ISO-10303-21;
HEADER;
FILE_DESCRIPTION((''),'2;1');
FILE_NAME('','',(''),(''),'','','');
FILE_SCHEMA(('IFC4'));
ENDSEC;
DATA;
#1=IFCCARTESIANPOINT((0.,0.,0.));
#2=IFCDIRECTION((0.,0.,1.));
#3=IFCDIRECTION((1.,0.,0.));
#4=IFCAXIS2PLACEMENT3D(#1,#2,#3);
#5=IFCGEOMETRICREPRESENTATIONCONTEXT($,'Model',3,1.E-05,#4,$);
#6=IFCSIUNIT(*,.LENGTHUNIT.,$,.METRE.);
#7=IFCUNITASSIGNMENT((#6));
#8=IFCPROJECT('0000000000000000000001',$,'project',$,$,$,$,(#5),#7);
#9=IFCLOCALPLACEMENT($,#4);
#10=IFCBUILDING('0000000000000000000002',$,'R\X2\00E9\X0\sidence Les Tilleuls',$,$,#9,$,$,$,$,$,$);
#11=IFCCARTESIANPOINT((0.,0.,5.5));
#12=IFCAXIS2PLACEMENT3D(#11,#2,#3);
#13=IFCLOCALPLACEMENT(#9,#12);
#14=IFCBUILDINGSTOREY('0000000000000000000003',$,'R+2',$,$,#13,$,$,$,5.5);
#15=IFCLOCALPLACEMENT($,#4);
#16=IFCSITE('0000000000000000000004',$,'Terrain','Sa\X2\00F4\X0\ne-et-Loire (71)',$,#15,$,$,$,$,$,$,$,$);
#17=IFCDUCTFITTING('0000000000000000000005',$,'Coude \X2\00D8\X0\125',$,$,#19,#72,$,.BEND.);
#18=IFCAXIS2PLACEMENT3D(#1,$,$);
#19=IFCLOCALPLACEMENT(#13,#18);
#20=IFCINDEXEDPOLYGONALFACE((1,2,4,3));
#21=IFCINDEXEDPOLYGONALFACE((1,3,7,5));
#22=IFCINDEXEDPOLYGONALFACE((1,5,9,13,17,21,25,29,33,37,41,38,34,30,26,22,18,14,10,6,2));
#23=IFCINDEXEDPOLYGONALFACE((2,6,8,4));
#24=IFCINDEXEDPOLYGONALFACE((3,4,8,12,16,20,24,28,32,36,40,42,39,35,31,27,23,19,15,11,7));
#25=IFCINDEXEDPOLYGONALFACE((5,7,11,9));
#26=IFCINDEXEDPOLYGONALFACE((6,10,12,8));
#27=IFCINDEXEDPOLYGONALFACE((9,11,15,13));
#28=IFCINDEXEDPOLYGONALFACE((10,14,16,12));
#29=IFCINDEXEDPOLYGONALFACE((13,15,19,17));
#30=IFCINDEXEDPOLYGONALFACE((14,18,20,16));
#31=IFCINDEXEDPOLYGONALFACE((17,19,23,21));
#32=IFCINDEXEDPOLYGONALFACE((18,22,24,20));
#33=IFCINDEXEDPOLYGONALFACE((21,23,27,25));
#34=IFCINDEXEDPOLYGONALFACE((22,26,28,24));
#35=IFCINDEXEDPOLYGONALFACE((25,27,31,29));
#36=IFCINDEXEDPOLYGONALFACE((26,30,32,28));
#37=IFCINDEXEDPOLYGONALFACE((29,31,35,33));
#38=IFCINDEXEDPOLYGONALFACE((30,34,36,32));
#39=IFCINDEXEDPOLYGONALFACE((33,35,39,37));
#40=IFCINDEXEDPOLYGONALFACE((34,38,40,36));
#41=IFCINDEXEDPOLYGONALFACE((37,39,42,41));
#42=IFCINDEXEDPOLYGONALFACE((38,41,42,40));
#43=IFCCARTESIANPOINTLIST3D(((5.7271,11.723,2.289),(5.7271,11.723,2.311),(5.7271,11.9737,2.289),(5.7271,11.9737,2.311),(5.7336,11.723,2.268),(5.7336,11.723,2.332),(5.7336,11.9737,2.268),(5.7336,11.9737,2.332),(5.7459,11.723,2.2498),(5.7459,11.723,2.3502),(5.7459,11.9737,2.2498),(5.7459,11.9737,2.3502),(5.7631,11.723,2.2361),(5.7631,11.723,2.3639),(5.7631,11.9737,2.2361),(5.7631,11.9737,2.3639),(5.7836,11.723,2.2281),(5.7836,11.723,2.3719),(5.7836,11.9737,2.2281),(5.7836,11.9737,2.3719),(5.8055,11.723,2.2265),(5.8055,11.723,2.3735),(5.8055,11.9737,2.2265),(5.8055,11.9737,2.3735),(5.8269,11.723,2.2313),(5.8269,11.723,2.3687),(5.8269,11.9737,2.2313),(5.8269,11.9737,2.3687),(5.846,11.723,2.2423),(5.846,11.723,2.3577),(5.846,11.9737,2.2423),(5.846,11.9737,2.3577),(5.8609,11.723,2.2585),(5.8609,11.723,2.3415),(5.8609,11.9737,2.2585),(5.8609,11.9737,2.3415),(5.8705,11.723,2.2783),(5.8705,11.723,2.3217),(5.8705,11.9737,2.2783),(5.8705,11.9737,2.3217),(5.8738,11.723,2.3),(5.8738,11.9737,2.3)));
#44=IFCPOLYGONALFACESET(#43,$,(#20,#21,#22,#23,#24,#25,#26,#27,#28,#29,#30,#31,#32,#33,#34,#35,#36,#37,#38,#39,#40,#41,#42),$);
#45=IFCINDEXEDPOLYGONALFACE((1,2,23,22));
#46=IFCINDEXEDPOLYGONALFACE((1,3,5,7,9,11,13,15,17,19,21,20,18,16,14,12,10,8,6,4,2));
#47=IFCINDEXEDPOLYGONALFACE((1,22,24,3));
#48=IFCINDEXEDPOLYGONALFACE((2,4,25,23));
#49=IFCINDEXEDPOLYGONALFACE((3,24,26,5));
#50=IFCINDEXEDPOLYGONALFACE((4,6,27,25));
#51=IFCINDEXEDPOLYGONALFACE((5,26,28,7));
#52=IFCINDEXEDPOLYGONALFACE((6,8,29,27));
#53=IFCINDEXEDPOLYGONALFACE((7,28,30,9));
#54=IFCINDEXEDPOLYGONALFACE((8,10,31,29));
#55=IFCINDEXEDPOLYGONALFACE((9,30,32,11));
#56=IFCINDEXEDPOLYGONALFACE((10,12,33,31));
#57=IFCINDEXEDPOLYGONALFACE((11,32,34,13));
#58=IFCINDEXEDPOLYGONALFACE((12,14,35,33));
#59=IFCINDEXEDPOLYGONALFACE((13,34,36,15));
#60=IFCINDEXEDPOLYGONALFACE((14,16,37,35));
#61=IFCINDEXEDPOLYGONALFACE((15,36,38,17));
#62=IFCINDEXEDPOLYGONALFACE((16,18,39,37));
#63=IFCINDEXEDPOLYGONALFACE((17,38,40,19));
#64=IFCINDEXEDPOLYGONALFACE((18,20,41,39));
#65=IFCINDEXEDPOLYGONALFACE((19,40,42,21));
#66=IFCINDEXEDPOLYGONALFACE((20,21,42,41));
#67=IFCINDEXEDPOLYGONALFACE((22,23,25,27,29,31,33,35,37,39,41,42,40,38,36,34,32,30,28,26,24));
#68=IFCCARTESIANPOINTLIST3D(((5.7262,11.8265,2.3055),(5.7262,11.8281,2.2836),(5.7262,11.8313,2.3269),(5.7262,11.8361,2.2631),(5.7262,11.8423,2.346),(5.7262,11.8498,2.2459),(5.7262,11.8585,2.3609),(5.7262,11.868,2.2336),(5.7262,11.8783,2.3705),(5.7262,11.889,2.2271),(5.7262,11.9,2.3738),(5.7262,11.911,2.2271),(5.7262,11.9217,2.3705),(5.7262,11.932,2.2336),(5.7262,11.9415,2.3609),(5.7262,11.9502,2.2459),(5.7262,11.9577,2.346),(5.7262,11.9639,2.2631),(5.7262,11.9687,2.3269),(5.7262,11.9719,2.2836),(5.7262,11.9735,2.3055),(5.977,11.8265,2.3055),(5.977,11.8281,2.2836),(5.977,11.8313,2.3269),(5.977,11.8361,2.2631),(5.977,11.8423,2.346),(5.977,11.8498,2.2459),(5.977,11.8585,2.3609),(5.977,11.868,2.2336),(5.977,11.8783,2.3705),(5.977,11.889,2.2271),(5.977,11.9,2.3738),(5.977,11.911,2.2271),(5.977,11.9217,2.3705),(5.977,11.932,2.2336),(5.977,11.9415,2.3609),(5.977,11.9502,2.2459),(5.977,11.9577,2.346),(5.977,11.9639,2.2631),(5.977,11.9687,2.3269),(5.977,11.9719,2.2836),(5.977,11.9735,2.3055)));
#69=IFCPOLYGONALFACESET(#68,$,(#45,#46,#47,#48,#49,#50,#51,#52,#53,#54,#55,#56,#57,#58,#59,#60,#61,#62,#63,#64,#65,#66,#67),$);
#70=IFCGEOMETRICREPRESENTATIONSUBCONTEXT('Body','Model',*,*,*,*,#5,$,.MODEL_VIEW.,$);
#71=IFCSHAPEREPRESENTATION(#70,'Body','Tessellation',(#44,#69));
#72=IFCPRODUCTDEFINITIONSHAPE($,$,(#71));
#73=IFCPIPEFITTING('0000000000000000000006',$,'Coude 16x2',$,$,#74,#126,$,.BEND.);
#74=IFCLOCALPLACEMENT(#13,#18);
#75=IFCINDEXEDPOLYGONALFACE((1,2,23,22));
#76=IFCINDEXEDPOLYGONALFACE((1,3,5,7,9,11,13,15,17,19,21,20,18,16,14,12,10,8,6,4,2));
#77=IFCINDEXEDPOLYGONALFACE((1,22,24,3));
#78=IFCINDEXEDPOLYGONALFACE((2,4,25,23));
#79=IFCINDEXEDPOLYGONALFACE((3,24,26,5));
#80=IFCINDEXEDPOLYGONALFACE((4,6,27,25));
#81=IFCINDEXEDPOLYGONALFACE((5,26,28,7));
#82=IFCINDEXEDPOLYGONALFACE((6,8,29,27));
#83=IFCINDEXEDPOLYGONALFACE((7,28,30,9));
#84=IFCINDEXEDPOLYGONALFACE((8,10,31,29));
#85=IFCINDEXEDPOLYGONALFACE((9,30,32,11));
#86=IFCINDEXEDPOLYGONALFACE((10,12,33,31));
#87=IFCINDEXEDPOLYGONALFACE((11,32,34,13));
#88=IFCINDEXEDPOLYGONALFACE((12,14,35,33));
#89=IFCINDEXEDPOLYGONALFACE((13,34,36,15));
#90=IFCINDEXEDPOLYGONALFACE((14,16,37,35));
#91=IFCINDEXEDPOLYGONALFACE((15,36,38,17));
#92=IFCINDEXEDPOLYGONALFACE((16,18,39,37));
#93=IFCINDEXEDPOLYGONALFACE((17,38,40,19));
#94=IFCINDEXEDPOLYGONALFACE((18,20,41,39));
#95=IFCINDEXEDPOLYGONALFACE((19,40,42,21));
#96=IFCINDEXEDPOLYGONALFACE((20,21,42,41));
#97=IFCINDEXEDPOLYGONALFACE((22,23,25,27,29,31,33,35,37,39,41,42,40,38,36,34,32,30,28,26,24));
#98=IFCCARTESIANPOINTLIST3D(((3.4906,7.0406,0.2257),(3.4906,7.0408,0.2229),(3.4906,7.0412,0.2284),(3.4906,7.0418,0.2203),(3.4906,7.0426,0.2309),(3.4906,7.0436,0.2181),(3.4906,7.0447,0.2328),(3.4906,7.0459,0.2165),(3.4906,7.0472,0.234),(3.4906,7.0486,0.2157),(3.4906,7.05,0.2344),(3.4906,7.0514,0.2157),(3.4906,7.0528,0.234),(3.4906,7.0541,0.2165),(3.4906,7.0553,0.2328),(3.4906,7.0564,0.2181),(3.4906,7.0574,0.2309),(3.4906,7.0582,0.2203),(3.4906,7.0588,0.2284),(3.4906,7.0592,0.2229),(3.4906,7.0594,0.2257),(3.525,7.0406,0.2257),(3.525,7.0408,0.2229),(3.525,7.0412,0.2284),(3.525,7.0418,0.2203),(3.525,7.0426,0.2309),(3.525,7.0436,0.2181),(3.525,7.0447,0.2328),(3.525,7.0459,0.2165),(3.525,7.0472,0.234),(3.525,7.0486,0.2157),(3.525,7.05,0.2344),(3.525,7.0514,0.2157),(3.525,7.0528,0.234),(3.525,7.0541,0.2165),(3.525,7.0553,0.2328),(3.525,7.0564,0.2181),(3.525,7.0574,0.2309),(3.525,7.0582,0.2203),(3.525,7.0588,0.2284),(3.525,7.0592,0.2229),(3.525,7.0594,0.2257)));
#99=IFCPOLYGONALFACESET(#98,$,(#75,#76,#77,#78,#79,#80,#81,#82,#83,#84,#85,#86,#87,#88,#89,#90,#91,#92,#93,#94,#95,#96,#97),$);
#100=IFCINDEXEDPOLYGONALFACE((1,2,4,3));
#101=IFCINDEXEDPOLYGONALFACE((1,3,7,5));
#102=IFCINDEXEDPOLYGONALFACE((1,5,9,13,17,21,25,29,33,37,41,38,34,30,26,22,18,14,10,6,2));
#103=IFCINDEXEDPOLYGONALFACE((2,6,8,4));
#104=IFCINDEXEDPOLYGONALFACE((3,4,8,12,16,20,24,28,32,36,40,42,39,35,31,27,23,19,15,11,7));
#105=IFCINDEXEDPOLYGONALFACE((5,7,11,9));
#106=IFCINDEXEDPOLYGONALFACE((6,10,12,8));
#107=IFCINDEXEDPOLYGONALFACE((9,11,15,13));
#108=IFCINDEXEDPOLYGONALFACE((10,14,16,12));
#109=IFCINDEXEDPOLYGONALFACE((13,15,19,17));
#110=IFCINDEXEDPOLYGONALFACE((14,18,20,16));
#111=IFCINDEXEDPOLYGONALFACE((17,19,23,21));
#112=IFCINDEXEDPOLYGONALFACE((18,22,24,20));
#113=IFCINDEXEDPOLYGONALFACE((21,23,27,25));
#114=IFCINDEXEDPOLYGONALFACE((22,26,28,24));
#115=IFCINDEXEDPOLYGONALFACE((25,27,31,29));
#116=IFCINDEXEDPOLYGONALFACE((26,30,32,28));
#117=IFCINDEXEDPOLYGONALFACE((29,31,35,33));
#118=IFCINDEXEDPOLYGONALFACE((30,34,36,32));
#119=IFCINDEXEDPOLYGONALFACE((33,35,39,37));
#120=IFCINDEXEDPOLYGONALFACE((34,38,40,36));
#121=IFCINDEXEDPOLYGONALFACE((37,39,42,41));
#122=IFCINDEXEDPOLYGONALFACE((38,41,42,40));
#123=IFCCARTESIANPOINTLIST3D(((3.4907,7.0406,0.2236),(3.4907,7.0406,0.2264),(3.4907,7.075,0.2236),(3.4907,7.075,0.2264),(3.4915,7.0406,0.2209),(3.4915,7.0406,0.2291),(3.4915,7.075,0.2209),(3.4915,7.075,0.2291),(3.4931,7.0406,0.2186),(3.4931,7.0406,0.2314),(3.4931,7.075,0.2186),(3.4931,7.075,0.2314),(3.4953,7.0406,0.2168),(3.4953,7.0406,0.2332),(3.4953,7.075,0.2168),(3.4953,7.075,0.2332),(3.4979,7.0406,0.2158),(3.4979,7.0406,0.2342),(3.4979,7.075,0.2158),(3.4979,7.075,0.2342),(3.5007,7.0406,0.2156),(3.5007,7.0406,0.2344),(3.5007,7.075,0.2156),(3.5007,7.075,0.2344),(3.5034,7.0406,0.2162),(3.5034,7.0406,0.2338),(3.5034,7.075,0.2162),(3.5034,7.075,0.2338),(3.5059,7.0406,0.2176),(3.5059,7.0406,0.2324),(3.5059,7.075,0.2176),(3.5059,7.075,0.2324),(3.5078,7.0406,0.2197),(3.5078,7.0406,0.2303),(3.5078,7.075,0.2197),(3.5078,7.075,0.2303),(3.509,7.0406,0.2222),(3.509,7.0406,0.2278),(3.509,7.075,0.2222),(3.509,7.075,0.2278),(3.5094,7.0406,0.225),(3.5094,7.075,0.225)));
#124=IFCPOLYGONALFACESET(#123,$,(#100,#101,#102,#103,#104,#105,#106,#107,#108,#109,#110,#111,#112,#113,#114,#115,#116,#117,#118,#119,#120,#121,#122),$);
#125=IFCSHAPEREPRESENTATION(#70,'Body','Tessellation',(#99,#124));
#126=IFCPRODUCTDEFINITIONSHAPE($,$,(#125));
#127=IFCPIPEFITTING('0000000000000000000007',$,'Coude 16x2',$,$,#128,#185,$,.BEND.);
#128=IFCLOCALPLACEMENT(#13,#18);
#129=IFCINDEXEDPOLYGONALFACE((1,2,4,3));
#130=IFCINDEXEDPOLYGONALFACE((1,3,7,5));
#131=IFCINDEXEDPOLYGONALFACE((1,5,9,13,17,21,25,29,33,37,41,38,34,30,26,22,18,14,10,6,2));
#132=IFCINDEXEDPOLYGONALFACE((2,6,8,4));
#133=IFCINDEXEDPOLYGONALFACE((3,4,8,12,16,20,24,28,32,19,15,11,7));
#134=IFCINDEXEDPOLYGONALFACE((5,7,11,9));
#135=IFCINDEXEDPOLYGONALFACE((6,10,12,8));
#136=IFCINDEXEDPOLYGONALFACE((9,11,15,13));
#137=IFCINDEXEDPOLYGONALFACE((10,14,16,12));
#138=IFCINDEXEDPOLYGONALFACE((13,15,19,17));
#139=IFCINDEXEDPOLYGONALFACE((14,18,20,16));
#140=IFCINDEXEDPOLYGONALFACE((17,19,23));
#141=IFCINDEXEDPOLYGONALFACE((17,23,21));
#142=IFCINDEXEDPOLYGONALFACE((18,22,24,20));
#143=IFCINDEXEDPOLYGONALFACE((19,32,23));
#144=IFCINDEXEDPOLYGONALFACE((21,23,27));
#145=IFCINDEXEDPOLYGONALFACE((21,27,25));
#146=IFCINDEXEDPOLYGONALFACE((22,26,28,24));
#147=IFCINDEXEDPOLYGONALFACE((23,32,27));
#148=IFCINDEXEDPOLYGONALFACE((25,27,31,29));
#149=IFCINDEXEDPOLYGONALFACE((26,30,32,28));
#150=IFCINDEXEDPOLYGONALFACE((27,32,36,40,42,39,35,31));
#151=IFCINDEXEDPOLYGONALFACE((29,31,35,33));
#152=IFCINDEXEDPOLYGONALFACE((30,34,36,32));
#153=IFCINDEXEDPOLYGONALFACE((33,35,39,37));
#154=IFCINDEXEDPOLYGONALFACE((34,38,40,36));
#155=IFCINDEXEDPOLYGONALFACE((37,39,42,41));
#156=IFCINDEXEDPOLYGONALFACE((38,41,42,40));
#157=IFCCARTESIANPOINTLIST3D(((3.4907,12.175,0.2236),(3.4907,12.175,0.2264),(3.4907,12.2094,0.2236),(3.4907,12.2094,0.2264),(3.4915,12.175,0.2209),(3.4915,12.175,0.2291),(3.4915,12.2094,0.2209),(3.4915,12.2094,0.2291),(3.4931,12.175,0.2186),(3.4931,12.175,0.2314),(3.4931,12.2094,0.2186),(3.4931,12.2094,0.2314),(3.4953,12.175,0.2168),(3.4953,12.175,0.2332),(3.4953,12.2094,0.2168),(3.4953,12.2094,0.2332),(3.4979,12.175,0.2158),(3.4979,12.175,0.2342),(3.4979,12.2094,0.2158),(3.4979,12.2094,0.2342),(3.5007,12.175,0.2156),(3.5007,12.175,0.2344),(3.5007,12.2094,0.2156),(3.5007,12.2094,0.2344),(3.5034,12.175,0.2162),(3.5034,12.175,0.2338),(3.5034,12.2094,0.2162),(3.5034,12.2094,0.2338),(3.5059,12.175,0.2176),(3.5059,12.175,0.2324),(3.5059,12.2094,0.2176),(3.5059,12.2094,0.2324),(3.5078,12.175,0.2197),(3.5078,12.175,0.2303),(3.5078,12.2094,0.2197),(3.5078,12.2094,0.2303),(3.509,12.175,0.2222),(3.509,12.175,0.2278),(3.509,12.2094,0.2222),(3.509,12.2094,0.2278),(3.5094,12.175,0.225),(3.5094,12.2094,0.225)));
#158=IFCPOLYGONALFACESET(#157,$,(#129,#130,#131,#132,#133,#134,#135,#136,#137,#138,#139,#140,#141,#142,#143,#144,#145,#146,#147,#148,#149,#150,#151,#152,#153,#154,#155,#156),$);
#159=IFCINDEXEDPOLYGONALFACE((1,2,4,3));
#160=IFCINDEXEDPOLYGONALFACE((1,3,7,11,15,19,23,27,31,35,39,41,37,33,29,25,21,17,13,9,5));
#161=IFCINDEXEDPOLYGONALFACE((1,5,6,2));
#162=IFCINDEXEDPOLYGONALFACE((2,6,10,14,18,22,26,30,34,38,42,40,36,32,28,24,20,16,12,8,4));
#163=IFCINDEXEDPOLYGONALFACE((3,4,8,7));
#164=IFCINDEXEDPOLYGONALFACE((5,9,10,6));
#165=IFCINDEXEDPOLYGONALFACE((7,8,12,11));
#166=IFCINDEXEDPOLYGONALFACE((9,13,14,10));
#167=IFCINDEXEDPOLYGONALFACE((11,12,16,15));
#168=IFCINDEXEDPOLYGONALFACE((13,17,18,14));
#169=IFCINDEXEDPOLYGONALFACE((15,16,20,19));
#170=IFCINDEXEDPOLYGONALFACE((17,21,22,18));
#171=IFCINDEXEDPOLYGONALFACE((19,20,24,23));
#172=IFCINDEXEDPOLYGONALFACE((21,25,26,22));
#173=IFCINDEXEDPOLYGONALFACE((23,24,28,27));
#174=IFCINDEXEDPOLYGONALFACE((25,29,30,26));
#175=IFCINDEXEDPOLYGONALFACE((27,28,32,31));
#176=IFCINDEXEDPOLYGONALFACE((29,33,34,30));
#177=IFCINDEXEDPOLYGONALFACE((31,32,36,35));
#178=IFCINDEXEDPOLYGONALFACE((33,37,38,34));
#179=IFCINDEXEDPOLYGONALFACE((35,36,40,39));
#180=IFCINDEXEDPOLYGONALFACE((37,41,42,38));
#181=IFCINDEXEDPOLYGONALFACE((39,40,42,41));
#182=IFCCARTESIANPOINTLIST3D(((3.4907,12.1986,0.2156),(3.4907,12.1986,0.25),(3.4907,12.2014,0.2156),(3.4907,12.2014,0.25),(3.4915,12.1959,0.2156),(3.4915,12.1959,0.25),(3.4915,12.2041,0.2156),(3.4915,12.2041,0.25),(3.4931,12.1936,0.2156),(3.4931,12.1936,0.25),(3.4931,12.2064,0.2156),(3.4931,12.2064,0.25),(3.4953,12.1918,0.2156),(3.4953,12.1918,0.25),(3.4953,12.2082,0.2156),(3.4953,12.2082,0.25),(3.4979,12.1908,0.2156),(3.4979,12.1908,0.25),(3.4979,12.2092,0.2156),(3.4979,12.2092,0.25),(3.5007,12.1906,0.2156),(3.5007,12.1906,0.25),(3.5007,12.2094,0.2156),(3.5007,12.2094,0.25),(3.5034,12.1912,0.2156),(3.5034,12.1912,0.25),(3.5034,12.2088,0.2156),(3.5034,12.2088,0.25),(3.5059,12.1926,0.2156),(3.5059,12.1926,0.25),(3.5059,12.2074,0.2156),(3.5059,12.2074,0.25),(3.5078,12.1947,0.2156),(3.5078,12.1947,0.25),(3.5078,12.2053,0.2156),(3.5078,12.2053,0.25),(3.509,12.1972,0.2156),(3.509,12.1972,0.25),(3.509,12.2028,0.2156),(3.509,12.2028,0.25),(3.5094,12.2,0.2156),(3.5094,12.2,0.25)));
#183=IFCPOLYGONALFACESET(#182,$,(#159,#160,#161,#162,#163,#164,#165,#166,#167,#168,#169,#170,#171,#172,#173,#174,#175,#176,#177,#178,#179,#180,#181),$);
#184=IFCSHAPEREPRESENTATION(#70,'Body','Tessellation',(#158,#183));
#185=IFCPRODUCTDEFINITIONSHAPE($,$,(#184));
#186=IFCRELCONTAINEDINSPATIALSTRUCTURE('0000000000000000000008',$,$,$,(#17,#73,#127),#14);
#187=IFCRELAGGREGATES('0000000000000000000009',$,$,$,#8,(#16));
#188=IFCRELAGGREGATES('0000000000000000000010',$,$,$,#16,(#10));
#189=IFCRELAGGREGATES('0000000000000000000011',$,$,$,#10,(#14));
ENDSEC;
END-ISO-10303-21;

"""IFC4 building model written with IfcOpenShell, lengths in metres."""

from ifc_helpers import new_model, si_unit, frame, origin_with_axes, place, context, subcontext, project, spatial, circle, extrude, element, save


model = new_model("IFC4")

# Units and contexts
model_context = context("Model", 3, precision=1e-05, world=origin_with_axes())
body_context = subcontext(model_context, "Body", "Model", "MODEL_VIEW")
ifc_project = project(units=[si_unit("LENGTHUNIT", "METRE")], contexts=[model_context])

# Site, building, storey
site_placement = place(None, origin_with_axes())
site = spatial("IfcSite", under=ifc_project, at=site_placement, Name="Terrain", Description="Saône-et-Loire (71)")
building_placement = place(None, origin_with_axes())
building = spatial("IfcBuilding", under=site, at=building_placement, Name="Résidence Les Tilleuls")
storey_placement = place(building_placement, frame((0.0, 0.0, 5.5), z_axis=(0.0, 0.0, 1.0), x_axis=(1.0, 0.0, 0.0)))
storey = spatial("IfcBuildingStorey", under=building, at=storey_placement, Name="R+2", Elevation=5.5)

# Duct fitting
duct_fitting_1_placement = place(storey_placement, frame((5.8, 11.9, 2.3), z_axis=(0.0, 0.0, 1.0), x_axis=(1.0, 0.0, 0.0)))
element("IfcDuctFitting", 1, at=duct_fitting_1_placement, inside=storey, Name="Coude Ø125", PredefinedType="BEND", context=body_context, shape_type="SweptSolid", body=[
    extrude(circle(Radius=0.0737), frame((0.0, 0.0737, 0.0), z_axis=(0.0, -1.0, 0.0), x_axis=(1.0, 0.0, 0.0)), (0.0, 0.0, 1.0), 0.2507),
    extrude(circle(Radius=0.0737), frame((-0.0737, 0.0, 0.0), z_axis=(1.0, 0.0, 0.0), x_axis=(0.0, 0.0, 1.0)), (0.0, 0.0, 1.0), 0.2507),
])

# Pipe fittings
pipe_fitting_1_placement = place(storey_placement, frame((3.5, 7.05, 0.225), z_axis=(0.0, 0.0, 1.0), x_axis=(1.0, 0.0, 0.0)))
element("IfcPipeFitting", 2, at=pipe_fitting_1_placement, inside=storey, Name="Coude 16x2", PredefinedType="BEND", context=body_context, shape_type="SweptSolid", body=[
    extrude(circle(Radius=0.0094), frame((-0.0094, 0.0, 0.0), z_axis=(1.0, 0.0, 0.0), x_axis=(0.0, 0.0, 1.0)), (0.0, 0.0, 1.0), 0.0344),
    extrude(circle(Radius=0.0094), frame((0.0, -0.0094, 0.0), z_axis=(0.0, 1.0, 0.0), x_axis=(1.0, 0.0, 0.0)), (0.0, 0.0, 1.0), 0.0344),
])
for number, where, z_axis, x_axis, name in (
    (3, (3.5, 12.2, 0.225), (0.0, 0.0, 1.0), (1.0, 0.0, 0.0), "Coude 16x2"),
):
    element("IfcPipeFitting", number, at=place(storey_placement, frame(where, z_axis=z_axis, x_axis=x_axis)), inside=storey, Name=name, PredefinedType="BEND", context=body_context, shape_type="SweptSolid", body=[
        extrude(circle(Radius=0.0094), frame((0.0, 0.0094, 0.0), z_axis=(0.0, -1.0, 0.0), x_axis=(1.0, 0.0, 0.0)), (0.0, 0.0, 1.0), 0.0344),
        extrude(circle(Radius=0.0094), frame((0.0, 0.0, -0.0094), z_axis=(0.0, 0.0, 1.0), x_axis=(1.0, 0.0, 0.0)), (0.0, 0.0, 1.0), 0.0344),
    ])

save(model, "model.ifc")
